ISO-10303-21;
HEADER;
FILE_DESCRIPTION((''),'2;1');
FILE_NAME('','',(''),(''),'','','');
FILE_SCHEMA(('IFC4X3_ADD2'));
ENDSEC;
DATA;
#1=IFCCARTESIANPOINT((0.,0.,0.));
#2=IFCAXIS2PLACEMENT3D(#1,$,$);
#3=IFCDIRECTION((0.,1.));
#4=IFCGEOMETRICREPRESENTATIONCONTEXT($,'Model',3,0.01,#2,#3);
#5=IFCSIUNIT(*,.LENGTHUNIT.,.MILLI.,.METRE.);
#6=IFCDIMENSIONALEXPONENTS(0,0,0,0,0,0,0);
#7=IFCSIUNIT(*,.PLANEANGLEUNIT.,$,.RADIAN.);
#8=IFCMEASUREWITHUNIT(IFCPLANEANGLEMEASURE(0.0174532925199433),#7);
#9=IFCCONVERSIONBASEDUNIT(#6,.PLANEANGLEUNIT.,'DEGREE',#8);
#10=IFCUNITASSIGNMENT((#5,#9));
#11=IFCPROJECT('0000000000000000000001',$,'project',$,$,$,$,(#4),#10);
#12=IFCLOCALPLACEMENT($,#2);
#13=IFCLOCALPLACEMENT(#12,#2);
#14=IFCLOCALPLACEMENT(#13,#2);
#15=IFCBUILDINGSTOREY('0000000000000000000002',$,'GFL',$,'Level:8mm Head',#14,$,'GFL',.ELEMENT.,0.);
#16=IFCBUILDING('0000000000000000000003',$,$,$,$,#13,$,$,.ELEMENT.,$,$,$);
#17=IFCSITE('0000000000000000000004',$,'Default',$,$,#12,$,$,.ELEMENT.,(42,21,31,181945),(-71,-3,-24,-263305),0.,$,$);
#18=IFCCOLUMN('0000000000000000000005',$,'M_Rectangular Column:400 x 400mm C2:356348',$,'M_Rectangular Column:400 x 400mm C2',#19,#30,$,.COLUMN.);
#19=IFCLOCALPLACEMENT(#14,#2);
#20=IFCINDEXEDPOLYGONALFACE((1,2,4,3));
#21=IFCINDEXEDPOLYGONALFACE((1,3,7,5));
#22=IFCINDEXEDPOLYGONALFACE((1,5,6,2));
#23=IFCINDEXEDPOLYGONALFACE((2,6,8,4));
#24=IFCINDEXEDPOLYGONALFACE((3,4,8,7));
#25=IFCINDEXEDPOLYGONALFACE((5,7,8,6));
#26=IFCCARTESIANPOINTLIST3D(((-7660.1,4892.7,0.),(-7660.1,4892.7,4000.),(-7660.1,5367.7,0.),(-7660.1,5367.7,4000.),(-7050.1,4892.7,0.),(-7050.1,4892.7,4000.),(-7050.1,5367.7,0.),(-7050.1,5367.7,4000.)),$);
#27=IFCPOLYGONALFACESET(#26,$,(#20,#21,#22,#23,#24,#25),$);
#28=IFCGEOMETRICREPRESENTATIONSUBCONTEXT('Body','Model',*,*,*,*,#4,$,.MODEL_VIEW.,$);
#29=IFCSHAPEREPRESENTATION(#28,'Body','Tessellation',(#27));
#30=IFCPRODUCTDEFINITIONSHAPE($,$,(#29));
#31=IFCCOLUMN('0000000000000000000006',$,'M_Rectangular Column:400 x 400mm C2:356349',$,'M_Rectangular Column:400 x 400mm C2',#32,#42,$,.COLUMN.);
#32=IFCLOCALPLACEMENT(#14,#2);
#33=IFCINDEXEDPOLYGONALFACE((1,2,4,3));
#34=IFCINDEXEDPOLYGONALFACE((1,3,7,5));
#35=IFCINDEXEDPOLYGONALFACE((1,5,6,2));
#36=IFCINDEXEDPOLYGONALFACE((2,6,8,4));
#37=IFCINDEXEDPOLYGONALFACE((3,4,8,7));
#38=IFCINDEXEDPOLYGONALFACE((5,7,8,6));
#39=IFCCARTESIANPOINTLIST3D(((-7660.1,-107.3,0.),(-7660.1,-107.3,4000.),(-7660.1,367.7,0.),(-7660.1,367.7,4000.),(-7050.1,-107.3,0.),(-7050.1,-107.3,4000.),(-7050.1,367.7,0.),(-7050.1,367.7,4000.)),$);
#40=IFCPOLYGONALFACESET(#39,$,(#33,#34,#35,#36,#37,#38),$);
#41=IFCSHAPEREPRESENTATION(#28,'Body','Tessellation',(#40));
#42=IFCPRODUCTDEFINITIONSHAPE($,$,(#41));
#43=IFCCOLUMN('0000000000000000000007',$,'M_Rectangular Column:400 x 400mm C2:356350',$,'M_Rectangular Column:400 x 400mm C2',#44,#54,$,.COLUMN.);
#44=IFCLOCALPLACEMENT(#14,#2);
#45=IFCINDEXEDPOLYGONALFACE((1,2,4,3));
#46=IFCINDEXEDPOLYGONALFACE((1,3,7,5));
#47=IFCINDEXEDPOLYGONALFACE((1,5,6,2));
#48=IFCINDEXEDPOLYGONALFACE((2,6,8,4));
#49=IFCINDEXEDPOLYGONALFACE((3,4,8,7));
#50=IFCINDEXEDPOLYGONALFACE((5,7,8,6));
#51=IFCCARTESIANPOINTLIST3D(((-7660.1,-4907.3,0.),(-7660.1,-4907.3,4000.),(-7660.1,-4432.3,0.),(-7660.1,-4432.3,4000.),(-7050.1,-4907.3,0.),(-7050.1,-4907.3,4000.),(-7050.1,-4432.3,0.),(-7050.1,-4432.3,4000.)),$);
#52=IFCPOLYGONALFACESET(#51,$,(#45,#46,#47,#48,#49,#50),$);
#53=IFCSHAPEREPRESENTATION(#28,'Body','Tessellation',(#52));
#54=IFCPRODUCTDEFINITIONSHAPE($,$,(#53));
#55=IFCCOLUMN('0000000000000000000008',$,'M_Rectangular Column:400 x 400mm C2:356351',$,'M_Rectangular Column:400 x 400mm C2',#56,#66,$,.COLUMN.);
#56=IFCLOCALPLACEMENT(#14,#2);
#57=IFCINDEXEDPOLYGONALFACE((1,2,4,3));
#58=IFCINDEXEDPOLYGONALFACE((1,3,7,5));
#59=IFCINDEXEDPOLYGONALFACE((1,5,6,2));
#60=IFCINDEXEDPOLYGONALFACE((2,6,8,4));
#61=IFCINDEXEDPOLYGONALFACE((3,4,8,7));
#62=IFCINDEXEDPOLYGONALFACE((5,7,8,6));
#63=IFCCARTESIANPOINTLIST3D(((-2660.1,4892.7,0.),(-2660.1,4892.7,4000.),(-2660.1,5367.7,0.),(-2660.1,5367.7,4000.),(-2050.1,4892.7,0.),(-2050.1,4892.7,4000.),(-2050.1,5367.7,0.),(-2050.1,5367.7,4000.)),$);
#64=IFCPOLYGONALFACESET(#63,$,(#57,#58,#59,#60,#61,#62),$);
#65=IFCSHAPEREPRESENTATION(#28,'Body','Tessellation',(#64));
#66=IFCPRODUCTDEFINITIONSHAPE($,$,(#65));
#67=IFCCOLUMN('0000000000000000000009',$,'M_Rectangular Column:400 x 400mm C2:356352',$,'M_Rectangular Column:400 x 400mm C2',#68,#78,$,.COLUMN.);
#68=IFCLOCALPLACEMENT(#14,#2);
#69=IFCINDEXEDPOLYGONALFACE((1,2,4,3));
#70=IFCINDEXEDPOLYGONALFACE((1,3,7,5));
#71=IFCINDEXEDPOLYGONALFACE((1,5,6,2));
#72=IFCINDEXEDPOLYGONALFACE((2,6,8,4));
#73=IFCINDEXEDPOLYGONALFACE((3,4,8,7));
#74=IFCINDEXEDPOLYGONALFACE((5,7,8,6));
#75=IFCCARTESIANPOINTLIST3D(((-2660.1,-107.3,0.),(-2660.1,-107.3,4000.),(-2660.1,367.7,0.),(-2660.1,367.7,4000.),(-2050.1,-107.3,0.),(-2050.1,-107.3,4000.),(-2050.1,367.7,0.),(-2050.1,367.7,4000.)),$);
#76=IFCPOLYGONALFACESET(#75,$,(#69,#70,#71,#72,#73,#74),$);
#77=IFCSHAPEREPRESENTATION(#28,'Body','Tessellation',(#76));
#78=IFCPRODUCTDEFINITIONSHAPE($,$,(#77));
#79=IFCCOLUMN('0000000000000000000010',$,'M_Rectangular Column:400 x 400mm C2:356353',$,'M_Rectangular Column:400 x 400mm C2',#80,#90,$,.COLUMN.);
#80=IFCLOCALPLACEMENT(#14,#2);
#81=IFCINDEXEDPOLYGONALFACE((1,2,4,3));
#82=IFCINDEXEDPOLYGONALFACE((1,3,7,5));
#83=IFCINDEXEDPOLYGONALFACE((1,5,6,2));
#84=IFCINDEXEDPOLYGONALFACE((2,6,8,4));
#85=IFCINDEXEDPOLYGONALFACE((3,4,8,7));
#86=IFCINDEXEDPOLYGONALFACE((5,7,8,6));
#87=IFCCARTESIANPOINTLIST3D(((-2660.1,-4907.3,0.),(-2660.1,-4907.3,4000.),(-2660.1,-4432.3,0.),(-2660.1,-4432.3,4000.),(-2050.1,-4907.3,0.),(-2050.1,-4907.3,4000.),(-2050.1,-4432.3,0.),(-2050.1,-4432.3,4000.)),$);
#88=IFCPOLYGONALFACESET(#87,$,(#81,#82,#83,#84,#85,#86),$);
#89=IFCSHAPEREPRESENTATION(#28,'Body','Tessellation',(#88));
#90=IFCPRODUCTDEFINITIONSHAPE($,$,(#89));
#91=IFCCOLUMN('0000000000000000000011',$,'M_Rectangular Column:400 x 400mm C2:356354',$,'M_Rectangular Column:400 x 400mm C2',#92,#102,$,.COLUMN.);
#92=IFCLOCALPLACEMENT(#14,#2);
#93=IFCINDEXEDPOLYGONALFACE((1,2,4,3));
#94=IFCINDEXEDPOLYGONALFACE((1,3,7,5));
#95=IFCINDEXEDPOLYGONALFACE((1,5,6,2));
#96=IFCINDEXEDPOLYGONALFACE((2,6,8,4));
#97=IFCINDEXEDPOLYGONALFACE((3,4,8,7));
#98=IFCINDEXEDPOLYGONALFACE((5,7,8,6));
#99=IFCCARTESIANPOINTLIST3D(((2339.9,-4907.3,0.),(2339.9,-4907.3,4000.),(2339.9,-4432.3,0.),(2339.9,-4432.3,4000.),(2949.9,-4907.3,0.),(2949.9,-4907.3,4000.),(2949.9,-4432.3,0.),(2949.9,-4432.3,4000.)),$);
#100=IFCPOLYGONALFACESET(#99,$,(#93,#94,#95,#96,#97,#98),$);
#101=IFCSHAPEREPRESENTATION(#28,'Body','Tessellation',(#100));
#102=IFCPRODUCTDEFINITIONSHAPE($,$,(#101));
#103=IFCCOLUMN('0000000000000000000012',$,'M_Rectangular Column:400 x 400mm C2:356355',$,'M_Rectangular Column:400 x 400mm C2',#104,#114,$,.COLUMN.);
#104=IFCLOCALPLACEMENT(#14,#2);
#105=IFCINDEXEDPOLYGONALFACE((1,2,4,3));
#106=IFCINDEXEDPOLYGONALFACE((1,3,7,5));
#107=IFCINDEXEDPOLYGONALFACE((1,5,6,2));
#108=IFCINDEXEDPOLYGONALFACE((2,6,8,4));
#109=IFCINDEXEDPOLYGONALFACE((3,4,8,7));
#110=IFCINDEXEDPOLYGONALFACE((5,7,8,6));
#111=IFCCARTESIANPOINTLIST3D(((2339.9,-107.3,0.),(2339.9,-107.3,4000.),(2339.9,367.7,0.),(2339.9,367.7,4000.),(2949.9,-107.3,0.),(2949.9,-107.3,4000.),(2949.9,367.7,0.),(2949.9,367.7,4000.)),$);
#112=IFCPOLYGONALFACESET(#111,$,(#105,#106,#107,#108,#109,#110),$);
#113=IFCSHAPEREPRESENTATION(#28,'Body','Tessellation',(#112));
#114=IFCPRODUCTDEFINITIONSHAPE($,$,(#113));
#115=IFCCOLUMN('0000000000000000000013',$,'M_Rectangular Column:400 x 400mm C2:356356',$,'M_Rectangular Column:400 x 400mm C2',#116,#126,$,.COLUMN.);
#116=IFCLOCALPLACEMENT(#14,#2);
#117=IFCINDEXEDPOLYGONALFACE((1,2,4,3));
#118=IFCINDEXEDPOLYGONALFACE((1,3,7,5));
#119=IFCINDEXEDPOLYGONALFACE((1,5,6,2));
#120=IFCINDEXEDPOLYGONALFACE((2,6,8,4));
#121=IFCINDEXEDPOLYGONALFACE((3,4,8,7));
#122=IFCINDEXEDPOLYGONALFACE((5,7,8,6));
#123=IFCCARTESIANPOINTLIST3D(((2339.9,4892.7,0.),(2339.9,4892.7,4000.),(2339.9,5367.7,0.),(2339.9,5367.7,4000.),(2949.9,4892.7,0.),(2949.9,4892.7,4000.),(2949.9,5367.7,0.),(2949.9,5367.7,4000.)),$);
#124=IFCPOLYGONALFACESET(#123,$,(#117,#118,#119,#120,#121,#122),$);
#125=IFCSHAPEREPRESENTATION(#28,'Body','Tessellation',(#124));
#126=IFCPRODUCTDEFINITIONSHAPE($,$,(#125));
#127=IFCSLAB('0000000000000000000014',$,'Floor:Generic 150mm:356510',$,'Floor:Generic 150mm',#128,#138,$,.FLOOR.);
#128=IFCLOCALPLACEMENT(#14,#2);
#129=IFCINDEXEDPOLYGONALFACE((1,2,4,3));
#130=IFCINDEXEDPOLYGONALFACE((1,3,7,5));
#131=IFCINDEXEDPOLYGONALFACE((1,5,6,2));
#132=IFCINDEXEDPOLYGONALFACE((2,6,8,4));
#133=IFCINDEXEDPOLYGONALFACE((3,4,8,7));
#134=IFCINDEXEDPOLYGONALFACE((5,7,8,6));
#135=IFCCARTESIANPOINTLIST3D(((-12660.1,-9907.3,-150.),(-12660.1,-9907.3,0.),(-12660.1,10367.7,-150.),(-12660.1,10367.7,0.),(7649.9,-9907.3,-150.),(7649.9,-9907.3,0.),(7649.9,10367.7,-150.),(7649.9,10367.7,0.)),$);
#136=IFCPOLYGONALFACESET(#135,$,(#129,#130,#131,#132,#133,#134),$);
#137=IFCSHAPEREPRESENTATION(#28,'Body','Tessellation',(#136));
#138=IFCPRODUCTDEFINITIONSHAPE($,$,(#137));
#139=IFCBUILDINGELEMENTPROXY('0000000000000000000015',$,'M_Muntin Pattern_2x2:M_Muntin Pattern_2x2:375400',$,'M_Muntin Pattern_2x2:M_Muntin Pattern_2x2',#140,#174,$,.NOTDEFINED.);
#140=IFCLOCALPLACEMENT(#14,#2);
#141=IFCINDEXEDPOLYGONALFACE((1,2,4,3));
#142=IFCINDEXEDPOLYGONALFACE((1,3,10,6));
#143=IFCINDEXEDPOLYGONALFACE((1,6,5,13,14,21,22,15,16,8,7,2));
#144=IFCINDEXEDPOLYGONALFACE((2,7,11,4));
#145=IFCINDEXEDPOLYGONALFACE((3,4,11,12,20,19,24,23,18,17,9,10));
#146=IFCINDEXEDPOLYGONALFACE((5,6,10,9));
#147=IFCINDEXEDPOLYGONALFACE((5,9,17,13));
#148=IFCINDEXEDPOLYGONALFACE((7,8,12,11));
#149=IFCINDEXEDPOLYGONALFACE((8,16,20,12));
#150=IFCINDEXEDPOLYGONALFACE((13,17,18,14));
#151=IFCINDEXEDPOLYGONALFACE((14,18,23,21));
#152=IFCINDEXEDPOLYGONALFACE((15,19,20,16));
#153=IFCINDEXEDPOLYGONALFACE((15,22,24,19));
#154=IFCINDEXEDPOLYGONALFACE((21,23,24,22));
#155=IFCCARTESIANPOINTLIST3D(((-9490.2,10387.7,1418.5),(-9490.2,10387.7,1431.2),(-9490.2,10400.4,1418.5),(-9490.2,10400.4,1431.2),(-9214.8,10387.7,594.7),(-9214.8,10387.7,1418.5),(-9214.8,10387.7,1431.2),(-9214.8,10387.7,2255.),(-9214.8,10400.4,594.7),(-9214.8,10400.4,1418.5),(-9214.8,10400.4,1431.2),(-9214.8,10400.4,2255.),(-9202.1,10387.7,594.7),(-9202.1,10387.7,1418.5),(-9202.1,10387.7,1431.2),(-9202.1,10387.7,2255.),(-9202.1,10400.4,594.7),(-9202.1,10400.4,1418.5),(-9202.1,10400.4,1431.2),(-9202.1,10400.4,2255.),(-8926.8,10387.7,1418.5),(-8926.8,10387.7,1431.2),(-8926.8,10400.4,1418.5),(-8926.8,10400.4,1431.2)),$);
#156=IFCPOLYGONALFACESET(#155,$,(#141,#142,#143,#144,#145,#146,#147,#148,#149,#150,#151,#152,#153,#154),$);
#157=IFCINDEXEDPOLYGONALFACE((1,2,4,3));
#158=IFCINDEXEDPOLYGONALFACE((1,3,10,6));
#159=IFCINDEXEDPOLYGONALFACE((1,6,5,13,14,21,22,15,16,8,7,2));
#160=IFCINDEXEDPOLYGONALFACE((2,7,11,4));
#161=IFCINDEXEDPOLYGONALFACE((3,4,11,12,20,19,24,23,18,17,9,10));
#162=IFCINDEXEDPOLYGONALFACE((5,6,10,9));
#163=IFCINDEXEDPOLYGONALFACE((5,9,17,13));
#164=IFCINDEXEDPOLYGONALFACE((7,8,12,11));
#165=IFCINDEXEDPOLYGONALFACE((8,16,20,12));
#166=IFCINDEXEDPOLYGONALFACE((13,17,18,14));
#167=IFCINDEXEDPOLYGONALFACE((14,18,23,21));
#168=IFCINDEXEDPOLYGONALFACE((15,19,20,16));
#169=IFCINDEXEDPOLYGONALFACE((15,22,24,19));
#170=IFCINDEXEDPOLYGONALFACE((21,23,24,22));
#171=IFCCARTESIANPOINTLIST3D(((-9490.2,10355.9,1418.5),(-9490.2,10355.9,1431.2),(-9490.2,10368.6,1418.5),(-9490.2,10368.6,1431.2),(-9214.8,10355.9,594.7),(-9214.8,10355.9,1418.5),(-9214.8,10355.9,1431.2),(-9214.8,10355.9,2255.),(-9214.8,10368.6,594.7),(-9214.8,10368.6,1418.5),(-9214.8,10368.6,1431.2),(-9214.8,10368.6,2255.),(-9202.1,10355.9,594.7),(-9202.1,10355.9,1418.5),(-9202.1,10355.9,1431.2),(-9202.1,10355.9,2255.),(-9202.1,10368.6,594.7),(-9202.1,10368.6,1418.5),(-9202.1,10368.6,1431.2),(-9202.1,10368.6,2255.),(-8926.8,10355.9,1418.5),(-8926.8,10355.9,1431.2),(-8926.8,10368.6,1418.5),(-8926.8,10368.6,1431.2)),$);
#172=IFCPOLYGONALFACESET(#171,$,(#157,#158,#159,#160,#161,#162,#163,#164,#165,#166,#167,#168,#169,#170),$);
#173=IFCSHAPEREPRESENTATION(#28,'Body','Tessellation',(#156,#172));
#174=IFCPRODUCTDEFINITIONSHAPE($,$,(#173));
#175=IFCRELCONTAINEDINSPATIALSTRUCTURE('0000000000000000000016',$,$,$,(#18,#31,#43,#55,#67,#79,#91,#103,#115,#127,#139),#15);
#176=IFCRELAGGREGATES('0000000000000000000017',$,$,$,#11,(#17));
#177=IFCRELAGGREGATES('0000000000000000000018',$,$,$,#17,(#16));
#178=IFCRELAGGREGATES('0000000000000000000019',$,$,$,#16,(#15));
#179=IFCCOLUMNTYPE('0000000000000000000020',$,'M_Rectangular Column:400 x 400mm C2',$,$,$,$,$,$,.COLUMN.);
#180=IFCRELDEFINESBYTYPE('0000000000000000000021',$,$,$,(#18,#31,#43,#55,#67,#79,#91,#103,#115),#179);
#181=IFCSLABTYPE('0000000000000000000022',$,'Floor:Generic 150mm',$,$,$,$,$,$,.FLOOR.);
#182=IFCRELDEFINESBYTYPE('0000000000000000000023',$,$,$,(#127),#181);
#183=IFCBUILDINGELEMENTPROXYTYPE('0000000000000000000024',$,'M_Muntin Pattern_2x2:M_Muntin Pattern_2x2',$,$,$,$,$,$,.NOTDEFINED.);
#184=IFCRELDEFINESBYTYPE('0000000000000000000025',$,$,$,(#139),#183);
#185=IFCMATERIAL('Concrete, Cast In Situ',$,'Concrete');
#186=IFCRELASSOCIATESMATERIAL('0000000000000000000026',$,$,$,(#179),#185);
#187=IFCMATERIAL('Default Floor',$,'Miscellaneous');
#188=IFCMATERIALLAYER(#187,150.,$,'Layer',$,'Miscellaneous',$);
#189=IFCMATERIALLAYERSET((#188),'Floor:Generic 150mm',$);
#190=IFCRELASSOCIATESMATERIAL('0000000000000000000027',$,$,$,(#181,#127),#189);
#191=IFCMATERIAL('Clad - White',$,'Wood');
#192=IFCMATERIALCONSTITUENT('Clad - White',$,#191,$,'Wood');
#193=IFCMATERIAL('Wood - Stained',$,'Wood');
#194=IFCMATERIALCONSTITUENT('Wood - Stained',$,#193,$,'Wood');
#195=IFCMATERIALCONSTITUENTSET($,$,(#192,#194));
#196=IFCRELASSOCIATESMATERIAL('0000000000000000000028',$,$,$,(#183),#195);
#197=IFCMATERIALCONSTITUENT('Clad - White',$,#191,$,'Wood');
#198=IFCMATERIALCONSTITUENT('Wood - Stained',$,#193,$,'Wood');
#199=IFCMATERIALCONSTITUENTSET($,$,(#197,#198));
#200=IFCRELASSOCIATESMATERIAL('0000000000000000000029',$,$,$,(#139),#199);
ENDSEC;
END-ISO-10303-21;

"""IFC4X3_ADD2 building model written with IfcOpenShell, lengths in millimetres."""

from ifc_helpers import new_model, entity, si_unit, converted_unit, direction, frame, origin, origin_2d_with_axis, place, context, subcontext, project, spatial, polyline, rectangle, outline, extrude, source, transform, mapped, material, layer, layer_set, layer_usage, constituent, constituent_set, material_profile, profile_set, type_object, type_shapes, element, save


model = new_model("IFC4X3_ADD2")

# Units and contexts
model_context = context("Model", 3, precision=0.01, world=origin(), true_north=direction((0.0, 1.0)))
body_context = subcontext(model_context, "Body", "Model", "MODEL_VIEW")
ifc_project = project(units=[si_unit("LENGTHUNIT", "METRE", prefix="MILLI"), converted_unit("PLANEANGLEUNIT", "DEGREE", entity("IfcPlaneAngleMeasure", 0.0174532925199433), si_unit("PLANEANGLEUNIT", "RADIAN"), dimensions=[0, 0, 0, 0, 0, 0, 0])], contexts=[model_context])

# Site, building, storey
site_placement = place(None, origin())
site = spatial("IfcSite", under=ifc_project, at=site_placement, Name="Default", CompositionType="ELEMENT", RefLatitude=(42, 21, 31, 181945), RefLongitude=(-71, -3, -24, -263305), RefElevation=0.0)
building_placement = place(site_placement, origin())
building = spatial("IfcBuilding", under=site, at=building_placement, CompositionType="ELEMENT")
storey_placement = place(building_placement, origin())
storey = spatial("IfcBuildingStorey", under=building, at=storey_placement, Name="GFL", ObjectType="Level:8mm Head", LongName="GFL", CompositionType="ELEMENT", Elevation=0.0)

# Columns
ifc_material_1 = material(Name="Concrete, Cast In Situ", Category="Concrete")
ifc_material_profile_1 = material_profile(ifc_material_1, rectangle(XDim=610.0, YDim=475.0, at=origin_2d_with_axis()), Name="400 x 400mm C2")
ifc_profile_set_1 = profile_set([ifc_material_profile_1], Name="400 x 400mm C2")
column_type_1 = type_object("IfcColumnType", Name="M_Rectangular Column:400 x 400mm C2", PredefinedType="COLUMN", material=ifc_profile_set_1)
shared_shape_1 = source(origin(), body_context, "Body", "SweptSolid", [
    extrude(rectangle(XDim=610.0, YDim=475.0, at=origin_2d_with_axis()), frame((0.0, 0.0, 0.0), z_axis=(0.0, 0.0, 1.0), x_axis=(-1.0, 0.0, 0.0)), (0.0, 0.0, 1.0), 4000.0),
])
type_shapes(column_type_1, [shared_shape_1])
for number, where, name in (
    (1, (-7355.1, 5130.2, 0.0), "M_Rectangular Column:400 x 400mm C2:356348"),
    (2, (-7355.1, 130.2, 0.0), "M_Rectangular Column:400 x 400mm C2:356349"),
    (3, (-7355.1, -4669.8, 0.0), "M_Rectangular Column:400 x 400mm C2:356350"),
    (4, (-2355.1, 5130.2, 0.0), "M_Rectangular Column:400 x 400mm C2:356351"),
    (5, (-2355.1, 130.2, 0.0), "M_Rectangular Column:400 x 400mm C2:356352"),
    (6, (-2355.1, -4669.8, 0.0), "M_Rectangular Column:400 x 400mm C2:356353"),
    (7, (2644.9, -4669.8, 0.0), "M_Rectangular Column:400 x 400mm C2:356354"),
    (8, (2644.9, 130.2, 0.0), "M_Rectangular Column:400 x 400mm C2:356355"),
    (9, (2644.9, 5130.2, 0.0), "M_Rectangular Column:400 x 400mm C2:356356"),
):
    element("IfcColumn", number, at=place(storey_placement, frame(where)), inside=storey, type_object=column_type_1, Name=name, ObjectType="M_Rectangular Column:400 x 400mm C2", PredefinedType="COLUMN", context=body_context, shape_type="MappedRepresentation", body=[
        mapped(shared_shape_1, transform((0.0, 0.0, 0.0), scale=1.0)),
    ])

# Slab
ifc_material_2 = material(Name="Default Floor", Category="Miscellaneous")
ifc_layer = layer(ifc_material_2, 150.0, Name="Layer", Category="Miscellaneous")
ifc_layer_set = layer_set([ifc_layer], Name="Floor:Generic 150mm")
ifc_layer_usage = layer_usage(ifc_layer_set, "AXIS3", "POSITIVE", 0.0)
slab_type = type_object("IfcSlabType", Name="Floor:Generic 150mm", PredefinedType="FLOOR", material=ifc_layer_set)
slab_placement = place(storey_placement, origin())
element("IfcSlab", 10, at=slab_placement, inside=storey, type_object=slab_type, material=ifc_layer_usage, Name="Floor:Generic 150mm:356510", ObjectType="Floor:Generic 150mm", PredefinedType="FLOOR", context=body_context, shape_type="SweptSolid", body=[
    extrude(rectangle(XDim=20275.0, YDim=20310.0, at=origin_2d_with_axis()), frame((-2505.1, 230.2, 0.0), z_axis=(0.0, 0.0, -1.0), x_axis=(0.0, 1.0, 0.0)), (0.0, 0.0, 1.0), 150.0),
])

# Building element proxy
ifc_material_3 = material(Name="Clad - White", Category="Wood")
ifc_constituent_1 = constituent(ifc_material_3, Name="Clad - White", Category="Wood")
ifc_material_4 = material(Name="Wood - Stained", Category="Wood")
ifc_constituent_2 = constituent(ifc_material_4, Name="Wood - Stained", Category="Wood")
ifc_constituent_set_1 = constituent_set(constituents=[ifc_constituent_1, ifc_constituent_2])
ifc_constituent_3 = constituent(ifc_material_3, Name="Clad - White", Category="Wood")
ifc_constituent_4 = constituent(ifc_material_4, Name="Wood - Stained", Category="Wood")
ifc_constituent_set_2 = constituent_set(constituents=[ifc_constituent_3, ifc_constituent_4])
building_element_proxy_type_1 = type_object("IfcBuildingElementProxyType", Name="M_Muntin Pattern_2x2:M_Muntin Pattern_2x2", PredefinedType="NOTDEFINED", material=ifc_constituent_set_2)
shared_shape_2 = source(origin(), body_context, "Body", "SweptSolid", [
    extrude(outline(polyline([(6.4, -6.4), (830.1, -6.4), (830.1, 6.3), (6.4, 6.3), (6.4, 281.7), (-6.3, 281.7), (-6.3, 6.3), (-830.2, 6.3), (-830.2, -6.4), (-6.3, -6.4), (-6.3, -281.7), (6.4, -281.7), (6.4, -6.4)])), frame((0.0, 9.5, 830.1), z_axis=(0.0, 1.0, 0.0), x_axis=(0.0, 0.0, 1.0)), (0.0, 0.0, 1.0), 12.7),
    extrude(outline(polyline([(6.4, -6.4), (830.2, -6.4), (830.2, 6.3), (6.4, 6.3), (6.4, 281.7), (-6.3, 281.7), (-6.3, 6.3), (-830.2, 6.3), (-830.2, -6.4), (-6.3, -6.4), (-6.3, -281.7), (6.4, -281.7), (6.4, -6.4)])), frame((0.0, -22.2, 830.2), z_axis=(0.0, 1.0, 0.0), x_axis=(0.0, 0.0, 1.0)), (0.0, 0.0, 1.0), 12.7),
])
type_shapes(building_element_proxy_type_1, [shared_shape_2])
proxy_1_placement = place(storey_placement, frame((-9208.5, 10378.2, 594.7)))
element("IfcBuildingElementProxy", 11, at=proxy_1_placement, inside=storey, type_object=building_element_proxy_type_1, material=ifc_constituent_set_1, Name="M_Muntin Pattern_2x2:M_Muntin Pattern_2x2:375400", ObjectType="M_Muntin Pattern_2x2:M_Muntin Pattern_2x2", PredefinedType="NOTDEFINED", context=body_context, shape_type="MappedRepresentation", body=[
    mapped(shared_shape_2, transform((0.0, 0.0, 0.0), scale=1.0)),
])

save(model, "model.ifc")
